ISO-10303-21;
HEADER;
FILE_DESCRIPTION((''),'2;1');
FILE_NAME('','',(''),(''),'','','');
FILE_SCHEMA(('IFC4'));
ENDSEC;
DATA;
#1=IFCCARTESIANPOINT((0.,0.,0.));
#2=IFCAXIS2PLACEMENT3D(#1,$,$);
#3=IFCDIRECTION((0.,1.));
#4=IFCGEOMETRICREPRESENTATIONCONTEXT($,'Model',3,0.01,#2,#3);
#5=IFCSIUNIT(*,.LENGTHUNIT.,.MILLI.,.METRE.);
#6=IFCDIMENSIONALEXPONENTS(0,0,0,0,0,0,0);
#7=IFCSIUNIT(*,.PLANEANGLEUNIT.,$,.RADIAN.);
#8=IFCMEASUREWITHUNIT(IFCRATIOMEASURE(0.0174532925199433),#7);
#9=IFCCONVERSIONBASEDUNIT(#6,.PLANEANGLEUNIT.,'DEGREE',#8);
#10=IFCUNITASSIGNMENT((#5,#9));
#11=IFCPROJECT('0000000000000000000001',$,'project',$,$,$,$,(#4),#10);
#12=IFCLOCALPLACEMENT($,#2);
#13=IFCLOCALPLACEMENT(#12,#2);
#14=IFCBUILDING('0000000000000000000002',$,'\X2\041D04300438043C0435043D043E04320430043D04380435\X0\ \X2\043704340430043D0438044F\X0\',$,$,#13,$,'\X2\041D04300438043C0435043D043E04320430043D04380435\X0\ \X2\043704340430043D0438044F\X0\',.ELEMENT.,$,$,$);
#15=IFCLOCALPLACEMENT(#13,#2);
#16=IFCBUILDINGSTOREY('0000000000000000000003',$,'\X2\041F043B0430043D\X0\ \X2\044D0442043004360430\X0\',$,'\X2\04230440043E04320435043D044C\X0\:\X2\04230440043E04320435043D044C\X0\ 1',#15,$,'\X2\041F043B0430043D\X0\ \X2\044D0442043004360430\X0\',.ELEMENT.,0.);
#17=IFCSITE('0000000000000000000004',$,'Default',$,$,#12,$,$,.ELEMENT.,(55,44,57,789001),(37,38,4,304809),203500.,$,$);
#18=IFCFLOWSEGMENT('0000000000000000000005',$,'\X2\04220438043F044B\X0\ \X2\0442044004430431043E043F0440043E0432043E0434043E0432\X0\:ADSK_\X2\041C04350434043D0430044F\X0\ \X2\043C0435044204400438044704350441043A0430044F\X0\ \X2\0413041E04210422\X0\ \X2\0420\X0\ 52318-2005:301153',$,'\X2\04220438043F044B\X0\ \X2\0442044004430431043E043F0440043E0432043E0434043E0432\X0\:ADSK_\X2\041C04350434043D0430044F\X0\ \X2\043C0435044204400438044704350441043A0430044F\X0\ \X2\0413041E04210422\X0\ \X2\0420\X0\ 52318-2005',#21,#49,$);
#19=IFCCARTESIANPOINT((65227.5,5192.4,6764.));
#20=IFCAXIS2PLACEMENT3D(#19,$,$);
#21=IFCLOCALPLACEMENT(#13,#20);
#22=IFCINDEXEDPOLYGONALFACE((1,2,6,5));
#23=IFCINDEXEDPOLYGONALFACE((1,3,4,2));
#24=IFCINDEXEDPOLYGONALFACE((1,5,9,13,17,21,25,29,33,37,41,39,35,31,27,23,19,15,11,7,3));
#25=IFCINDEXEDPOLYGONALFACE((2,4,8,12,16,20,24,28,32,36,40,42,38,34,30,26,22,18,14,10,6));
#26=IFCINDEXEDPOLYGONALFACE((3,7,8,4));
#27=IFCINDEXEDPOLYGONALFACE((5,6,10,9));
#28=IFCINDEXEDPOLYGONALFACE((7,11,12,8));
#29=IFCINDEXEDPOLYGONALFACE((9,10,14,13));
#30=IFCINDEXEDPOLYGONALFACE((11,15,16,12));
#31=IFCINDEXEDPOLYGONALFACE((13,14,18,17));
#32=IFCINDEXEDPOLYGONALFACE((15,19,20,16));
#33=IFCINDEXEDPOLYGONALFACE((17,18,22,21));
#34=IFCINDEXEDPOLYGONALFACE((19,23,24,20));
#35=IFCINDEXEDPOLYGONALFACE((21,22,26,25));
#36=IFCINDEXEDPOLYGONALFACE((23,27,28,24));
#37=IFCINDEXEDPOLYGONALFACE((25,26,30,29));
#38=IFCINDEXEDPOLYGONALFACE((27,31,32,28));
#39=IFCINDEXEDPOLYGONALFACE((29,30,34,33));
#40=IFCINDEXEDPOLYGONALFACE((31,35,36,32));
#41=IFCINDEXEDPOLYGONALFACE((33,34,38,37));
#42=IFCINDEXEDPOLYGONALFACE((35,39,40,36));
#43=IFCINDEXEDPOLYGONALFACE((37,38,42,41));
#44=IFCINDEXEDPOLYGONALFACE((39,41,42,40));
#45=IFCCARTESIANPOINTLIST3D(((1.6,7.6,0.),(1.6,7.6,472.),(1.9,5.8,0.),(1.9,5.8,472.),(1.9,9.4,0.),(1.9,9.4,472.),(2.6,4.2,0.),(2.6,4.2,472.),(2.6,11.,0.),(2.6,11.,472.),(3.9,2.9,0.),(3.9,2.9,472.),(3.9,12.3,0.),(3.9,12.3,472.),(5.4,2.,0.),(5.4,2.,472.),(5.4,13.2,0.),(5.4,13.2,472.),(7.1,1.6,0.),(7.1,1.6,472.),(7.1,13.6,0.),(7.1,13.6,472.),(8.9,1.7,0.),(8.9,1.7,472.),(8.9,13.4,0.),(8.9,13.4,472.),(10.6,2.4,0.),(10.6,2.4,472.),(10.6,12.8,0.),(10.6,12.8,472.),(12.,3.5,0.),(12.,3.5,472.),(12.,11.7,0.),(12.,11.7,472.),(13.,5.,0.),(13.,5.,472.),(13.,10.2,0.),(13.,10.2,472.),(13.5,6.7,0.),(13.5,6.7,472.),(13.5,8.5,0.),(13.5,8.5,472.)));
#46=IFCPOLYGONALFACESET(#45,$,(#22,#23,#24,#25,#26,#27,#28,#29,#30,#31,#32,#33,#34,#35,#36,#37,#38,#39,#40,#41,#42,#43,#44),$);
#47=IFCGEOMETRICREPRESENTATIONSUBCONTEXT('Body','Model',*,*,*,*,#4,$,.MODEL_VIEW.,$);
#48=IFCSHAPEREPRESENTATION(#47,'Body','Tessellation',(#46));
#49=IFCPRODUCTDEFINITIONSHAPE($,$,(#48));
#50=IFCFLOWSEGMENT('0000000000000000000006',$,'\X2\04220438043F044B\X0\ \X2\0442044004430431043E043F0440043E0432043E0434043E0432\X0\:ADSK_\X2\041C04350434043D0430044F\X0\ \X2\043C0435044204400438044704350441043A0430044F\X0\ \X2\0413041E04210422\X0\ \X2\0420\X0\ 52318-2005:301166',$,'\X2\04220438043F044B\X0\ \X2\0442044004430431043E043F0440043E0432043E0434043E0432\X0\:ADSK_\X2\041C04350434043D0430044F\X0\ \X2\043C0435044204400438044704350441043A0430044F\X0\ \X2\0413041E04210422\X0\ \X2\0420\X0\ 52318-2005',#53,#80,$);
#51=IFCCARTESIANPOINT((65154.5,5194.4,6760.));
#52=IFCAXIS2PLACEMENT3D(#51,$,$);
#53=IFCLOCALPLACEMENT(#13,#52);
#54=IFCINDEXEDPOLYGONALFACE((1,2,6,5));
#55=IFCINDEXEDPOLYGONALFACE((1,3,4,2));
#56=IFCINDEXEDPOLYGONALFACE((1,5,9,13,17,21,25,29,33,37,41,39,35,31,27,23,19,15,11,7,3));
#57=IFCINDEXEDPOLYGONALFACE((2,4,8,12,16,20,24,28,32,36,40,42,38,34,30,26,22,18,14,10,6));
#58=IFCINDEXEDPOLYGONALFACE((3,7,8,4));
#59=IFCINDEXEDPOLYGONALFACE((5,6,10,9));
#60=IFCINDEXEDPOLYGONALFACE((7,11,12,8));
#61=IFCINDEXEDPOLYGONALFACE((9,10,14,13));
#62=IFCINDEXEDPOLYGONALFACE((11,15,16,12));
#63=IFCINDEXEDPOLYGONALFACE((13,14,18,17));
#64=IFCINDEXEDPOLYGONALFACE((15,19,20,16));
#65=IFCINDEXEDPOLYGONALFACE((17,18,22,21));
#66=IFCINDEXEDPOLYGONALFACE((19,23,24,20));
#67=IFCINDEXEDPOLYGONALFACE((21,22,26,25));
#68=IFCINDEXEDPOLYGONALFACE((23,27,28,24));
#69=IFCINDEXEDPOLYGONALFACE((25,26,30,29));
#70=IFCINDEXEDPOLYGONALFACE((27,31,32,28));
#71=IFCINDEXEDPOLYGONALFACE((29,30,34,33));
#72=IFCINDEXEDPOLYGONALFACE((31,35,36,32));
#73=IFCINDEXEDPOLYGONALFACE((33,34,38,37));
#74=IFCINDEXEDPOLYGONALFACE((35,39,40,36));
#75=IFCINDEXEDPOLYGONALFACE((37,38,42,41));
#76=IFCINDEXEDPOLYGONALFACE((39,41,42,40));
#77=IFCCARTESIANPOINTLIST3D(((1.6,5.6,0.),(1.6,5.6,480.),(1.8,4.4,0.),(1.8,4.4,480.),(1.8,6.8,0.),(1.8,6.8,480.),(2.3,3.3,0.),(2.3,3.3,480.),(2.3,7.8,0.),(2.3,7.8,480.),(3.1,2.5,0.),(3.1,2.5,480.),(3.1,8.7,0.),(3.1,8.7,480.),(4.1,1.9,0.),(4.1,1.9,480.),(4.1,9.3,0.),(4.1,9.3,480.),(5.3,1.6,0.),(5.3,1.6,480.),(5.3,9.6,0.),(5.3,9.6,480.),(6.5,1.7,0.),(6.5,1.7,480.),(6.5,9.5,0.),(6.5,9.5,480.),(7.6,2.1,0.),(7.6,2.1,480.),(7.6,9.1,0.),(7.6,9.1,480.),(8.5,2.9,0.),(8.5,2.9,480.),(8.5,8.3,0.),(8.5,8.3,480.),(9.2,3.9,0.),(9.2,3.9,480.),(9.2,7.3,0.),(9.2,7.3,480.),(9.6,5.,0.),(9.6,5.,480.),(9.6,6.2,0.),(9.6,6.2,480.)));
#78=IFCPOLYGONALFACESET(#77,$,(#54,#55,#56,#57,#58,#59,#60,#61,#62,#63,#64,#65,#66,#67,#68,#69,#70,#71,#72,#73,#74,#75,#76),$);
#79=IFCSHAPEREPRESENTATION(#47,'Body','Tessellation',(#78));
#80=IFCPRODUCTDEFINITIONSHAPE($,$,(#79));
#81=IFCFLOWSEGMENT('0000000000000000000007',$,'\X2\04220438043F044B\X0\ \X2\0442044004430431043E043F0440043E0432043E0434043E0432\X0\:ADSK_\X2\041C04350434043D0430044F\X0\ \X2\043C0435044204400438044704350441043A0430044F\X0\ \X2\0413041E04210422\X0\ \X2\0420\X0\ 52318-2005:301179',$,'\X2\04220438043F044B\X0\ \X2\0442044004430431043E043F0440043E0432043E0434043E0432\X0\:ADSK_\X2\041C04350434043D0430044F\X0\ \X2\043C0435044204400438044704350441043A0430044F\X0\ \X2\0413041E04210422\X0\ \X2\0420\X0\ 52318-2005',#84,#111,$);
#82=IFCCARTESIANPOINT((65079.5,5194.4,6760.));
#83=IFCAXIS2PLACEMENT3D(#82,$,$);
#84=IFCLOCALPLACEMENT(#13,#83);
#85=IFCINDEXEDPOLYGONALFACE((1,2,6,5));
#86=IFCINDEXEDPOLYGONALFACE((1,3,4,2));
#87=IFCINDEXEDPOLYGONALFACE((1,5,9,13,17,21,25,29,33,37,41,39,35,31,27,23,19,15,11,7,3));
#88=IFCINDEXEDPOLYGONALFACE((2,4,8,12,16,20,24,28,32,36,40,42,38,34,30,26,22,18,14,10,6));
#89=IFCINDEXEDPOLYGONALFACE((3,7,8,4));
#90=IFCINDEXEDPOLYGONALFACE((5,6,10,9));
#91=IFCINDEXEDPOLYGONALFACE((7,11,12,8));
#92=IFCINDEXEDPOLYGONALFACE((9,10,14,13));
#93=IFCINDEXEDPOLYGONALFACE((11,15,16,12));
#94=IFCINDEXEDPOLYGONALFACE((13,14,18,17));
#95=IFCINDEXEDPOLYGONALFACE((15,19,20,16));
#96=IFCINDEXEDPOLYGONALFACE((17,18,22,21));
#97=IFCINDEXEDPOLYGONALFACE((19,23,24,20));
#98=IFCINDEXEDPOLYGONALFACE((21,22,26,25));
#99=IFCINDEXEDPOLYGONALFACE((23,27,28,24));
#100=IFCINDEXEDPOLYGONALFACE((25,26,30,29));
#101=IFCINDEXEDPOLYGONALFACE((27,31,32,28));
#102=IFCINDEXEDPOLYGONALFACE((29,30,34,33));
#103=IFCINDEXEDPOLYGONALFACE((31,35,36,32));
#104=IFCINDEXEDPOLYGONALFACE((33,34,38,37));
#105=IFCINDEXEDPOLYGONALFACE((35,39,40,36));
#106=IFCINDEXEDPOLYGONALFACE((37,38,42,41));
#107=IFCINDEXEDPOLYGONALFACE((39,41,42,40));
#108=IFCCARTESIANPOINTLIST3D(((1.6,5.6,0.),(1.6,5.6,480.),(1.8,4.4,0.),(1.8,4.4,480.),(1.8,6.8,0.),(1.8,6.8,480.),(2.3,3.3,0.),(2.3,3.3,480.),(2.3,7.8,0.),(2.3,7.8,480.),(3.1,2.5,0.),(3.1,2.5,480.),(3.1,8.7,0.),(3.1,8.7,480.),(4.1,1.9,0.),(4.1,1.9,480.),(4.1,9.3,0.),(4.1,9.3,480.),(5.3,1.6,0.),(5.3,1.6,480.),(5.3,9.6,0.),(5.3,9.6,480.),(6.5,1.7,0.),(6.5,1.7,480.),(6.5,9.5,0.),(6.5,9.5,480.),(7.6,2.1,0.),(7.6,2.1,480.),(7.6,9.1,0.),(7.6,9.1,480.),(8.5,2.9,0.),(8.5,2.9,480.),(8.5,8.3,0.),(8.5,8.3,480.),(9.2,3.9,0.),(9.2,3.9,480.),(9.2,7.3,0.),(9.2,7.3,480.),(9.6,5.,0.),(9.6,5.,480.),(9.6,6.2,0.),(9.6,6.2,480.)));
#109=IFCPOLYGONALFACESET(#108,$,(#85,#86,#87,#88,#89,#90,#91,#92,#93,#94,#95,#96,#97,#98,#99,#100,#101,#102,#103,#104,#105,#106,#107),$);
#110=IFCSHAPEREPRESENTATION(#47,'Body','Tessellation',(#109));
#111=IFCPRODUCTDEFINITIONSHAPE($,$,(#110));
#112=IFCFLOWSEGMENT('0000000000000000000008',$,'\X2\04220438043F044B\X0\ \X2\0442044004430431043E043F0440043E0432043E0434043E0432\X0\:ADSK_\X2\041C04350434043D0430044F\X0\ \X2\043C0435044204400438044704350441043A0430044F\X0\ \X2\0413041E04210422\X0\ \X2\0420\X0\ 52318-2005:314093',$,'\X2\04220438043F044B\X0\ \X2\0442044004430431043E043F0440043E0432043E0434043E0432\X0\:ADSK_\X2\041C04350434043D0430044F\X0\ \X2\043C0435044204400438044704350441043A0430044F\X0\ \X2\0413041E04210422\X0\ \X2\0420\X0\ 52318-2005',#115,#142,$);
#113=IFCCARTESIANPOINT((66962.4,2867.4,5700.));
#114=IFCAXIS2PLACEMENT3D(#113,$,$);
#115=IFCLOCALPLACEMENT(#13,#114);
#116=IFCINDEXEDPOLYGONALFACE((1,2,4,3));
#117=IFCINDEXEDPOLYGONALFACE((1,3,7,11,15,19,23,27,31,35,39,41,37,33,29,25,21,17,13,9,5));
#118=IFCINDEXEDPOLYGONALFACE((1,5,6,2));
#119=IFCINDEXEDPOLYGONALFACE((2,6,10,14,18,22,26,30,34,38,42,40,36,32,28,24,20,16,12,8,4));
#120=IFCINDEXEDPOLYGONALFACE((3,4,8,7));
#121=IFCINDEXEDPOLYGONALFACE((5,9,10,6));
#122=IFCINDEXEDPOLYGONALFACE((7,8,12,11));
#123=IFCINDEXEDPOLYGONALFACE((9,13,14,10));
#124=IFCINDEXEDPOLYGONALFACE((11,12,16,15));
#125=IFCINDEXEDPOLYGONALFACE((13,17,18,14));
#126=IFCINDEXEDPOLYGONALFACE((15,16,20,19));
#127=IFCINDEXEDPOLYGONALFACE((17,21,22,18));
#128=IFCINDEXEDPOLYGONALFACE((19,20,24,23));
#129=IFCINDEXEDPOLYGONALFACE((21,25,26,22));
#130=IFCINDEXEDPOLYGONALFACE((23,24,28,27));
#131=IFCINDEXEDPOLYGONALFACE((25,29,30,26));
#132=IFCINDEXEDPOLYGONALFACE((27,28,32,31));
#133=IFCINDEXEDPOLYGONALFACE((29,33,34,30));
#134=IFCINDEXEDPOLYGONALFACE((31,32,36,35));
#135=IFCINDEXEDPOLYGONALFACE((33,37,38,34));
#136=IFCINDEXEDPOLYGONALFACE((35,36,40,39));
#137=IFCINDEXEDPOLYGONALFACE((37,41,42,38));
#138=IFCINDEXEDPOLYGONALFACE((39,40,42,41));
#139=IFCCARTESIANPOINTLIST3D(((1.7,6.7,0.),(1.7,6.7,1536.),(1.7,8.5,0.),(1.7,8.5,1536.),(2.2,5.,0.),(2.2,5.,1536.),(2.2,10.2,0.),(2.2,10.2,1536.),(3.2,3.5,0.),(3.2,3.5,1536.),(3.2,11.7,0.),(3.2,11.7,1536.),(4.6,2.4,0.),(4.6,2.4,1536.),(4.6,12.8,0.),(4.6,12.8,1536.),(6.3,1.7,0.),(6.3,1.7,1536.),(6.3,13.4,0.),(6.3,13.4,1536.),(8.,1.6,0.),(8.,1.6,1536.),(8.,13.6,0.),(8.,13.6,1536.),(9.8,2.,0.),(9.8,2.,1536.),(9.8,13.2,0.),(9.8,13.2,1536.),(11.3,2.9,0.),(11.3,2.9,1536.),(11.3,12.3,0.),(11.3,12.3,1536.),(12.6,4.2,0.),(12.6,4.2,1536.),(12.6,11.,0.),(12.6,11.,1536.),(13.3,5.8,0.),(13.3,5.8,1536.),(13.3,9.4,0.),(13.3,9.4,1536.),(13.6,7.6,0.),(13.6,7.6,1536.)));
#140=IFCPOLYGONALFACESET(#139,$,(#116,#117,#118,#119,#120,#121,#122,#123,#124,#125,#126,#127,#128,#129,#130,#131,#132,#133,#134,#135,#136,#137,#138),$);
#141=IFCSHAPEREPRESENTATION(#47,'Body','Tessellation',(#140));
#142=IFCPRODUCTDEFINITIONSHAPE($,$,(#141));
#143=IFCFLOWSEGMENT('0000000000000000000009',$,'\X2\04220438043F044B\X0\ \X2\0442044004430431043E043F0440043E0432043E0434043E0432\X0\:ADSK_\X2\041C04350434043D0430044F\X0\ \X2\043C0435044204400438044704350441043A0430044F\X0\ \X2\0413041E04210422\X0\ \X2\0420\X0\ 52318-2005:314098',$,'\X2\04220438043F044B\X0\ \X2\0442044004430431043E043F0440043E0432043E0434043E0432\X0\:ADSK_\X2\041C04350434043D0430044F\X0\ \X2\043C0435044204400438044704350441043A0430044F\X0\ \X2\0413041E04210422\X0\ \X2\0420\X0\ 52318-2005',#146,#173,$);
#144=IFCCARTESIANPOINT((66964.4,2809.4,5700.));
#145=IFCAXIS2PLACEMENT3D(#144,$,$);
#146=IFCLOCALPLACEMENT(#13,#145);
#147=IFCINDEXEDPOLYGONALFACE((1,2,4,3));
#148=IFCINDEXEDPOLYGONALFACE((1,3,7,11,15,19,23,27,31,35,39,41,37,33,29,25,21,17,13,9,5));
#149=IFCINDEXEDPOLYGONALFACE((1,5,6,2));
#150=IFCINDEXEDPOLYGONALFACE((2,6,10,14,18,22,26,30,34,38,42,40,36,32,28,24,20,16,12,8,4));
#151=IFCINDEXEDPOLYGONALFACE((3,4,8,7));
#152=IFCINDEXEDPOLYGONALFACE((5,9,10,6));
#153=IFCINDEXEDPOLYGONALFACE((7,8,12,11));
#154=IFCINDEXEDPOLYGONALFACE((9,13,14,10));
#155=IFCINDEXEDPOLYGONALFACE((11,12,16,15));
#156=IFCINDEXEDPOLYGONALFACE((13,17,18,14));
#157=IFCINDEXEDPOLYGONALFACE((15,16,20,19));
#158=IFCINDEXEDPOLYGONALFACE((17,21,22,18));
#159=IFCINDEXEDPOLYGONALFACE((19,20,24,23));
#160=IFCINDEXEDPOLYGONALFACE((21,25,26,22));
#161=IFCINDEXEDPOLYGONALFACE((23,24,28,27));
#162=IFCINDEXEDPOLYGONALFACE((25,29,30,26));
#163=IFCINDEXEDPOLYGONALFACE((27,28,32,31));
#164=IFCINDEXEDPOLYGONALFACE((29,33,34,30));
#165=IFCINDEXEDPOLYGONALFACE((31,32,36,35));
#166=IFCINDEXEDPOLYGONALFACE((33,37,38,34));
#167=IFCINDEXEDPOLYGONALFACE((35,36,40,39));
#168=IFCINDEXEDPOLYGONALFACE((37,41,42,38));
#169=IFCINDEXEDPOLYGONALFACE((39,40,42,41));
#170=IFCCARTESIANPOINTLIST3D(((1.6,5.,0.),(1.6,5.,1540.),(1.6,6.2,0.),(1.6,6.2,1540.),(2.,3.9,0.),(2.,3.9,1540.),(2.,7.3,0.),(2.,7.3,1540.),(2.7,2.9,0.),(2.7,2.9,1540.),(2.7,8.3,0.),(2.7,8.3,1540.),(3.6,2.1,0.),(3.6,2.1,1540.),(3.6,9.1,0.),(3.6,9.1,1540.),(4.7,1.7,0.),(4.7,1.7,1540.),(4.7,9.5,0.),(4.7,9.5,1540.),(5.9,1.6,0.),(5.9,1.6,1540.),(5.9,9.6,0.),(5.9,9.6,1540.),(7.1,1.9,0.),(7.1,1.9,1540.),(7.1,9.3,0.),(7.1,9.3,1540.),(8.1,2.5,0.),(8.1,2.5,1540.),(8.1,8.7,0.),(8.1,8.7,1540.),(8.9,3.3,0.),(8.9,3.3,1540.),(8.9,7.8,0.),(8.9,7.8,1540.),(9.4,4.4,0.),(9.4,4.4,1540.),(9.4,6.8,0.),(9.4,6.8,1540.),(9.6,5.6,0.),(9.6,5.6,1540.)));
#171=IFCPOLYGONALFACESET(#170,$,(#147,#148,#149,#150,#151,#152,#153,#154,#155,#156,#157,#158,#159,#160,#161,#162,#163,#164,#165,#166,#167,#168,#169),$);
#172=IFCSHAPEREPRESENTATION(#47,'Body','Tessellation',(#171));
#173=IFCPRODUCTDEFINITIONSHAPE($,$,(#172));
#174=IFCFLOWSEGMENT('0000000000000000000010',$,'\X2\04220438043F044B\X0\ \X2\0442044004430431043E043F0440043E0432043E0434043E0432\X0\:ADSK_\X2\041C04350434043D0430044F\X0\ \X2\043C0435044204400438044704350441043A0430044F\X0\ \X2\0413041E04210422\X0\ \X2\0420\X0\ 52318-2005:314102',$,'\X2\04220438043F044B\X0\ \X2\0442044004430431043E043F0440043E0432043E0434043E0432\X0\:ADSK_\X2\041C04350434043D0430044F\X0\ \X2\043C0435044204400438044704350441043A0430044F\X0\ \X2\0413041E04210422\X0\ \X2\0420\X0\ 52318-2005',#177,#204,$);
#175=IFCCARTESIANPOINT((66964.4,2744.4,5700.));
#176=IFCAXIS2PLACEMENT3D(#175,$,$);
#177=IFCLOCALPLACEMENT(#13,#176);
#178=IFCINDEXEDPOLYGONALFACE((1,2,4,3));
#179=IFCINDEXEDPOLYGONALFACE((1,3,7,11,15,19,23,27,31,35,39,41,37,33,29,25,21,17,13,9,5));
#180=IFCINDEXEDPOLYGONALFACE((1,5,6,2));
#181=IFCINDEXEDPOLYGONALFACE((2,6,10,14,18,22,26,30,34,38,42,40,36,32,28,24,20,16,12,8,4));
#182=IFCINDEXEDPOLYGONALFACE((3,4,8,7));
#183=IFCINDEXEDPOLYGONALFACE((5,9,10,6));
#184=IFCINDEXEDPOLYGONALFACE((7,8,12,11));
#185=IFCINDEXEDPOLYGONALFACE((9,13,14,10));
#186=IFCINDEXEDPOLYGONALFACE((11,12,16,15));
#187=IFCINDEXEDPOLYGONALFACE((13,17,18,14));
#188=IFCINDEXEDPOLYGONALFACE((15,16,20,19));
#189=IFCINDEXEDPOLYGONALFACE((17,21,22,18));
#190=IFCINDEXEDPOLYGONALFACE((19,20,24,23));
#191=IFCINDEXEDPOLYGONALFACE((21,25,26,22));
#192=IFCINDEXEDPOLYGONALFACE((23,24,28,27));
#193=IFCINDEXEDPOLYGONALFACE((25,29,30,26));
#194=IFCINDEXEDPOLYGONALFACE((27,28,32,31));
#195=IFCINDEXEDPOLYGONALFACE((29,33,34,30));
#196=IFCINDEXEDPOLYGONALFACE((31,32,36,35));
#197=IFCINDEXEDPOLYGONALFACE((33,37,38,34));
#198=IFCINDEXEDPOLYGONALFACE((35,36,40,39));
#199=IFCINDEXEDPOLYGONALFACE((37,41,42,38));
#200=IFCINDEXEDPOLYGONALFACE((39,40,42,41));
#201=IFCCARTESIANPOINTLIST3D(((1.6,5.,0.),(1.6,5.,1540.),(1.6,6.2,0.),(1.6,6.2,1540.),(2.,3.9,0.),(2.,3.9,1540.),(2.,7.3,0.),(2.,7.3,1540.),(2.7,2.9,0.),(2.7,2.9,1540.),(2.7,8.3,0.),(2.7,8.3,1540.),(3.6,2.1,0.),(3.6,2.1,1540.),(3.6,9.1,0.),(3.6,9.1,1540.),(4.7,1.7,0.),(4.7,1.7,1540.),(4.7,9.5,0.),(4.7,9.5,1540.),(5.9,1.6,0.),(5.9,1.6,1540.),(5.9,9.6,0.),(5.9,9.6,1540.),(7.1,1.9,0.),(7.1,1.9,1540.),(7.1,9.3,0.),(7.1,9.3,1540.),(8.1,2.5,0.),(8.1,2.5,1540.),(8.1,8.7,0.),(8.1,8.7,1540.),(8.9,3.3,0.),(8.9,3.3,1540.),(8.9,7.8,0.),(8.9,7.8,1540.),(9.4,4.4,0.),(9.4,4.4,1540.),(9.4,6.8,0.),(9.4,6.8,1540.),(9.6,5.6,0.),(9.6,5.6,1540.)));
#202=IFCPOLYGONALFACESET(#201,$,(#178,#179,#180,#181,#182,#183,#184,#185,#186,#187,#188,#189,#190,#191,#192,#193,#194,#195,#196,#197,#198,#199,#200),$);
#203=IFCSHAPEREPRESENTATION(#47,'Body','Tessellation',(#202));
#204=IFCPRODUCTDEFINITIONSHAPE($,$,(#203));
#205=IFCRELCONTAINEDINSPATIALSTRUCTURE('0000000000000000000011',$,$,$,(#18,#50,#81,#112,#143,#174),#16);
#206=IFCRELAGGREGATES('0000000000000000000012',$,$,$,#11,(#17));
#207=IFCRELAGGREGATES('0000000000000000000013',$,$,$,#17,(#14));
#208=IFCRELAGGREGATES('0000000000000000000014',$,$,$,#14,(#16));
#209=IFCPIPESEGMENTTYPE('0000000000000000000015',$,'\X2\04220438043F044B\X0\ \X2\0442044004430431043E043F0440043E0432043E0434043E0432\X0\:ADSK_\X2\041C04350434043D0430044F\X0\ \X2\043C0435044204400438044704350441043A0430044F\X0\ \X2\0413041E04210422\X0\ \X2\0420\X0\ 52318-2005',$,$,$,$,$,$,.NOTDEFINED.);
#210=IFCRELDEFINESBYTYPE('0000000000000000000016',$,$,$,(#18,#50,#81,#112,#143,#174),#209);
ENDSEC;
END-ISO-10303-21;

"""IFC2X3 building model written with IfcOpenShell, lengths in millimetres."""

from ifc_helpers import new_model, entity, si_unit, converted_unit, direction, frame, frame_2d, origin, origin_2d_with_axis, place, context, subcontext, project, spatial, circle, extrude, type_object, element, save


model = new_model("IFC2X3")

# Units and contexts
model_context = context("Model", 3, precision=0.01, world=origin(), true_north=direction((0.0, 1.0)))
body_context = subcontext(model_context, "Body", "Model", "MODEL_VIEW")
ifc_project = project(units=[si_unit("LENGTHUNIT", "METRE", prefix="MILLI"), converted_unit("PLANEANGLEUNIT", "DEGREE", entity("IfcRatioMeasure", 0.0174532925199433), si_unit("PLANEANGLEUNIT", "RADIAN"), dimensions=[0, 0, 0, 0, 0, 0, 0])], contexts=[model_context])

# Site, building, storey
site_placement = place(None, frame((0.0, 0.0, 0.0)))
site = spatial("IfcSite", under=ifc_project, at=site_placement, Name="Default", CompositionType="ELEMENT", RefLatitude=(55, 44, 57, 789001), RefLongitude=(37, 38, 4, 304809), RefElevation=203500.0)
building_placement = place(site_placement, origin())
building = spatial("IfcBuilding", under=site, at=building_placement, Name="Наименование здания", LongName="Наименование здания", CompositionType="ELEMENT")
storey_placement = place(building_placement, origin())
storey = spatial("IfcBuildingStorey", under=building, at=storey_placement, Name="План этажа", ObjectType="Уровень:Уровень 1", LongName="План этажа", CompositionType="ELEMENT", Elevation=0.0)

# Flow segments
pipe_segment_type = type_object("IfcPipeSegmentType", Name="Типы трубопроводов:ADSK_Медная метрическая ГОСТ Р 52318-2005", PredefinedType="NOTDEFINED")
flow_segment_1_placement = place(building_placement, frame((65227.5, 5192.4, 6764.0)))
element("IfcFlowSegment", 1, at=flow_segment_1_placement, inside=storey, type_object=pipe_segment_type, Name="Типы трубопроводов:ADSK_Медная метрическая ГОСТ Р 52318-2005:301153", ObjectType="Типы трубопроводов:ADSK_Медная метрическая ГОСТ Р 52318-2005", context=body_context, shape_type="SweptSolid", body=[
    extrude(circle(Radius=6.0, at=origin_2d_with_axis()), frame((7.6, 7.6, 0.0), z_axis=(0.0, 0.0, 1.0), x_axis=(-1.0, 0.0, 0.0)), (0.0, 0.0, 1.0), 472.0),
])
flow_segment_2_placement = place(building_placement, frame((65154.5, 5194.4, 6760.0)))
element("IfcFlowSegment", 2, at=flow_segment_2_placement, inside=storey, type_object=pipe_segment_type, Name="Типы трубопроводов:ADSK_Медная метрическая ГОСТ Р 52318-2005:301166", ObjectType="Типы трубопроводов:ADSK_Медная метрическая ГОСТ Р 52318-2005", context=body_context, shape_type="SweptSolid", body=[
    extrude(circle(Radius=4.0, at=origin_2d_with_axis()), frame((5.6, 5.6, 0.0), z_axis=(0.0, 0.0, 1.0), x_axis=(-1.0, 0.0, 0.0)), (0.0, 0.0, 1.0), 480.0),
])
flow_segment_3_placement = place(building_placement, frame((65079.5, 5194.4, 6760.0)))
element("IfcFlowSegment", 3, at=flow_segment_3_placement, inside=storey, type_object=pipe_segment_type, Name="Типы трубопроводов:ADSK_Медная метрическая ГОСТ Р 52318-2005:301179", ObjectType="Типы трубопроводов:ADSK_Медная метрическая ГОСТ Р 52318-2005", context=body_context, shape_type="SweptSolid", body=[
    extrude(circle(Radius=4.0, at=origin_2d_with_axis()), frame((5.6, 5.6, 0.0), z_axis=(0.0, 0.0, 1.0), x_axis=(-1.0, 0.0, 0.0)), (0.0, 0.0, 1.0), 480.0),
])
flow_segment_4_placement = place(building_placement, frame((66962.4, 2867.4, 5700.0)))
element("IfcFlowSegment", 4, at=flow_segment_4_placement, inside=storey, type_object=pipe_segment_type, Name="Типы трубопроводов:ADSK_Медная метрическая ГОСТ Р 52318-2005:314093", ObjectType="Типы трубопроводов:ADSK_Медная метрическая ГОСТ Р 52318-2005", context=body_context, shape_type="SweptSolid", body=[
    extrude(circle(Radius=6.0, at=frame_2d((0.0, 0.0), x_axis=(1.0, 0.0))), frame((7.6, 7.6, 0.0)), (0.0, 0.0, 1.0), 1536.0),
])
for number, where, name in (
    (5, (66964.4, 2809.4, 5700.0), "Типы трубопроводов:ADSK_Медная метрическая ГОСТ Р 52318-2005:314098"),
    (6, (66964.4, 2744.4, 5700.0), "Типы трубопроводов:ADSK_Медная метрическая ГОСТ Р 52318-2005:314102"),
):
    element("IfcFlowSegment", number, at=place(building_placement, frame(where)), inside=storey, type_object=pipe_segment_type, Name=name, ObjectType="Типы трубопроводов:ADSK_Медная метрическая ГОСТ Р 52318-2005", context=body_context, shape_type="SweptSolid", body=[
        extrude(circle(Radius=4.0, at=origin_2d_with_axis()), frame((5.6, 5.6, 0.0)), (0.0, 0.0, 1.0), 1540.0),
    ])

save(model, "model.ifc")
